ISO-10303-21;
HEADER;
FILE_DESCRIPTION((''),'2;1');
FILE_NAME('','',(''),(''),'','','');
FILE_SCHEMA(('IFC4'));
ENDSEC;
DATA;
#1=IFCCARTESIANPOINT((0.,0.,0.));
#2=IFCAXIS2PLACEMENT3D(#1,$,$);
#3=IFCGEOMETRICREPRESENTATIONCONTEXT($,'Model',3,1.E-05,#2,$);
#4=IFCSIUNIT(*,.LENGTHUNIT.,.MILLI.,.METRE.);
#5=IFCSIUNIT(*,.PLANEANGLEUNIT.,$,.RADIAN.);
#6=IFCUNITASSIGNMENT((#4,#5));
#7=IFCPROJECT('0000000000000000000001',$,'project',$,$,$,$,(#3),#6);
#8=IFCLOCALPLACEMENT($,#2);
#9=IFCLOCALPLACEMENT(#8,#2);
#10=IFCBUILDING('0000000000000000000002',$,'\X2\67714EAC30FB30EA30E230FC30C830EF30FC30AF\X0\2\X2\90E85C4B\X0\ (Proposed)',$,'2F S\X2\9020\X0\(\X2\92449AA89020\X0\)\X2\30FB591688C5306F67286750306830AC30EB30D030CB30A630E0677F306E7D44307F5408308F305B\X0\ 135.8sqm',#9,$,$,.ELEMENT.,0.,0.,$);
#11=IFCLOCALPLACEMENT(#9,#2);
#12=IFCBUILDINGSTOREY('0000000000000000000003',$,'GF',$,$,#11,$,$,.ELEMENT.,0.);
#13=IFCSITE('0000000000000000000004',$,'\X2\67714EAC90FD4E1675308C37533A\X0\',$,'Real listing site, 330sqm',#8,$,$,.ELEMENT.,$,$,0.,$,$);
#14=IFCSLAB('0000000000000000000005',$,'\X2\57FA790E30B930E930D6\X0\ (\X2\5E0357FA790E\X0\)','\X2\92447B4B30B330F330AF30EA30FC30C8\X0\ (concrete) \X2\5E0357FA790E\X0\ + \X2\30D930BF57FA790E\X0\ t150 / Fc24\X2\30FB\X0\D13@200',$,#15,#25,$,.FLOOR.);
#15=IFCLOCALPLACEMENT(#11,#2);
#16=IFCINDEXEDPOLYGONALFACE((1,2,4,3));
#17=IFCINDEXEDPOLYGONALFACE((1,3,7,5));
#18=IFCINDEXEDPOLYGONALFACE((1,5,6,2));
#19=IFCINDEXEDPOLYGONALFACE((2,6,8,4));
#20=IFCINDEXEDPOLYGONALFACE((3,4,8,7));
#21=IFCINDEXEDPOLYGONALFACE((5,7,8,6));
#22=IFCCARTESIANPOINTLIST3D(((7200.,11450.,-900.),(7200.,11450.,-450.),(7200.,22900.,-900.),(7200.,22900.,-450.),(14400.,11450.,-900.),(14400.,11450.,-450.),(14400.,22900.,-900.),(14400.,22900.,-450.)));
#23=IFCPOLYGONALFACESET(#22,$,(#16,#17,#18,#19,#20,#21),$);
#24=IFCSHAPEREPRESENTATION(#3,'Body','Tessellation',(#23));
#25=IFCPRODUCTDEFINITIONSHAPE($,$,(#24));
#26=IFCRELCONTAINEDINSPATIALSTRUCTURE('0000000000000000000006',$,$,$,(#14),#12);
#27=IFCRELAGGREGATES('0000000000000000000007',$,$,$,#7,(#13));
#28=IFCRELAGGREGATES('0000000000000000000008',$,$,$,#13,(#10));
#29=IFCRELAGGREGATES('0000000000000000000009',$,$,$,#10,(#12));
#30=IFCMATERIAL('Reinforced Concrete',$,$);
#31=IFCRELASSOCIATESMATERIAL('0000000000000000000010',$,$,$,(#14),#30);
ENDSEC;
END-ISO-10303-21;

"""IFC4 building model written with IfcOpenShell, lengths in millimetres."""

from ifc_helpers import new_model, si_unit, frame, frame_2d, origin, place, context, project, spatial, rectangle, extrude, material, element, save


model = new_model("IFC4")

# Units and contexts
model_context = context("Model", 3, precision=1e-05, world=origin())
ifc_project = project(units=[si_unit("LENGTHUNIT", "METRE", prefix="MILLI"), si_unit("PLANEANGLEUNIT", "RADIAN")], contexts=[model_context])

# Site, building, storey
site_placement = place(None, origin())
site = spatial("IfcSite", under=ifc_project, at=site_placement, Name="東京都世田谷区", ObjectType="Real listing site, 330sqm", CompositionType="ELEMENT", RefElevation=0.0)
building_placement = place(site_placement, origin())
building = spatial("IfcBuilding", under=site, at=building_placement, Name="東京・リモートワーク2部屋 (Proposed)", ObjectType="2F S造(鉄骨造)・外装は木材とガルバニウム板の組み合わせ 135.8sqm", CompositionType="ELEMENT", ElevationOfRefHeight=0.0, ElevationOfTerrain=0.0)
storey_placement = place(building_placement, origin())
storey = spatial("IfcBuildingStorey", under=building, at=storey_placement, Name="GF", CompositionType="ELEMENT", Elevation=0.0)

# Slab
ifc_material_1 = material(Name="Reinforced Concrete")
slab_1_placement = place(storey_placement, frame((3600.0, 5725.0, -450.0)))
element("IfcSlab", 1, at=slab_1_placement, inside=storey, material=ifc_material_1, Name="基礎スラブ (布基礎)", Description="鉄筋コンクリート (concrete) 布基礎 + ベタ基礎 t150 / Fc24・D13@200", PredefinedType="FLOOR", context=model_context, shape_type="SweptSolid", body=[
    extrude(rectangle(XDim=7200.0, YDim=11450.0, at=frame_2d((3600.0, 5725.0))), frame((3600.0, 5725.0, -450.0)), (0.0, 0.0, 1.0), 450.0),
])

save(model, "model.ifc")
